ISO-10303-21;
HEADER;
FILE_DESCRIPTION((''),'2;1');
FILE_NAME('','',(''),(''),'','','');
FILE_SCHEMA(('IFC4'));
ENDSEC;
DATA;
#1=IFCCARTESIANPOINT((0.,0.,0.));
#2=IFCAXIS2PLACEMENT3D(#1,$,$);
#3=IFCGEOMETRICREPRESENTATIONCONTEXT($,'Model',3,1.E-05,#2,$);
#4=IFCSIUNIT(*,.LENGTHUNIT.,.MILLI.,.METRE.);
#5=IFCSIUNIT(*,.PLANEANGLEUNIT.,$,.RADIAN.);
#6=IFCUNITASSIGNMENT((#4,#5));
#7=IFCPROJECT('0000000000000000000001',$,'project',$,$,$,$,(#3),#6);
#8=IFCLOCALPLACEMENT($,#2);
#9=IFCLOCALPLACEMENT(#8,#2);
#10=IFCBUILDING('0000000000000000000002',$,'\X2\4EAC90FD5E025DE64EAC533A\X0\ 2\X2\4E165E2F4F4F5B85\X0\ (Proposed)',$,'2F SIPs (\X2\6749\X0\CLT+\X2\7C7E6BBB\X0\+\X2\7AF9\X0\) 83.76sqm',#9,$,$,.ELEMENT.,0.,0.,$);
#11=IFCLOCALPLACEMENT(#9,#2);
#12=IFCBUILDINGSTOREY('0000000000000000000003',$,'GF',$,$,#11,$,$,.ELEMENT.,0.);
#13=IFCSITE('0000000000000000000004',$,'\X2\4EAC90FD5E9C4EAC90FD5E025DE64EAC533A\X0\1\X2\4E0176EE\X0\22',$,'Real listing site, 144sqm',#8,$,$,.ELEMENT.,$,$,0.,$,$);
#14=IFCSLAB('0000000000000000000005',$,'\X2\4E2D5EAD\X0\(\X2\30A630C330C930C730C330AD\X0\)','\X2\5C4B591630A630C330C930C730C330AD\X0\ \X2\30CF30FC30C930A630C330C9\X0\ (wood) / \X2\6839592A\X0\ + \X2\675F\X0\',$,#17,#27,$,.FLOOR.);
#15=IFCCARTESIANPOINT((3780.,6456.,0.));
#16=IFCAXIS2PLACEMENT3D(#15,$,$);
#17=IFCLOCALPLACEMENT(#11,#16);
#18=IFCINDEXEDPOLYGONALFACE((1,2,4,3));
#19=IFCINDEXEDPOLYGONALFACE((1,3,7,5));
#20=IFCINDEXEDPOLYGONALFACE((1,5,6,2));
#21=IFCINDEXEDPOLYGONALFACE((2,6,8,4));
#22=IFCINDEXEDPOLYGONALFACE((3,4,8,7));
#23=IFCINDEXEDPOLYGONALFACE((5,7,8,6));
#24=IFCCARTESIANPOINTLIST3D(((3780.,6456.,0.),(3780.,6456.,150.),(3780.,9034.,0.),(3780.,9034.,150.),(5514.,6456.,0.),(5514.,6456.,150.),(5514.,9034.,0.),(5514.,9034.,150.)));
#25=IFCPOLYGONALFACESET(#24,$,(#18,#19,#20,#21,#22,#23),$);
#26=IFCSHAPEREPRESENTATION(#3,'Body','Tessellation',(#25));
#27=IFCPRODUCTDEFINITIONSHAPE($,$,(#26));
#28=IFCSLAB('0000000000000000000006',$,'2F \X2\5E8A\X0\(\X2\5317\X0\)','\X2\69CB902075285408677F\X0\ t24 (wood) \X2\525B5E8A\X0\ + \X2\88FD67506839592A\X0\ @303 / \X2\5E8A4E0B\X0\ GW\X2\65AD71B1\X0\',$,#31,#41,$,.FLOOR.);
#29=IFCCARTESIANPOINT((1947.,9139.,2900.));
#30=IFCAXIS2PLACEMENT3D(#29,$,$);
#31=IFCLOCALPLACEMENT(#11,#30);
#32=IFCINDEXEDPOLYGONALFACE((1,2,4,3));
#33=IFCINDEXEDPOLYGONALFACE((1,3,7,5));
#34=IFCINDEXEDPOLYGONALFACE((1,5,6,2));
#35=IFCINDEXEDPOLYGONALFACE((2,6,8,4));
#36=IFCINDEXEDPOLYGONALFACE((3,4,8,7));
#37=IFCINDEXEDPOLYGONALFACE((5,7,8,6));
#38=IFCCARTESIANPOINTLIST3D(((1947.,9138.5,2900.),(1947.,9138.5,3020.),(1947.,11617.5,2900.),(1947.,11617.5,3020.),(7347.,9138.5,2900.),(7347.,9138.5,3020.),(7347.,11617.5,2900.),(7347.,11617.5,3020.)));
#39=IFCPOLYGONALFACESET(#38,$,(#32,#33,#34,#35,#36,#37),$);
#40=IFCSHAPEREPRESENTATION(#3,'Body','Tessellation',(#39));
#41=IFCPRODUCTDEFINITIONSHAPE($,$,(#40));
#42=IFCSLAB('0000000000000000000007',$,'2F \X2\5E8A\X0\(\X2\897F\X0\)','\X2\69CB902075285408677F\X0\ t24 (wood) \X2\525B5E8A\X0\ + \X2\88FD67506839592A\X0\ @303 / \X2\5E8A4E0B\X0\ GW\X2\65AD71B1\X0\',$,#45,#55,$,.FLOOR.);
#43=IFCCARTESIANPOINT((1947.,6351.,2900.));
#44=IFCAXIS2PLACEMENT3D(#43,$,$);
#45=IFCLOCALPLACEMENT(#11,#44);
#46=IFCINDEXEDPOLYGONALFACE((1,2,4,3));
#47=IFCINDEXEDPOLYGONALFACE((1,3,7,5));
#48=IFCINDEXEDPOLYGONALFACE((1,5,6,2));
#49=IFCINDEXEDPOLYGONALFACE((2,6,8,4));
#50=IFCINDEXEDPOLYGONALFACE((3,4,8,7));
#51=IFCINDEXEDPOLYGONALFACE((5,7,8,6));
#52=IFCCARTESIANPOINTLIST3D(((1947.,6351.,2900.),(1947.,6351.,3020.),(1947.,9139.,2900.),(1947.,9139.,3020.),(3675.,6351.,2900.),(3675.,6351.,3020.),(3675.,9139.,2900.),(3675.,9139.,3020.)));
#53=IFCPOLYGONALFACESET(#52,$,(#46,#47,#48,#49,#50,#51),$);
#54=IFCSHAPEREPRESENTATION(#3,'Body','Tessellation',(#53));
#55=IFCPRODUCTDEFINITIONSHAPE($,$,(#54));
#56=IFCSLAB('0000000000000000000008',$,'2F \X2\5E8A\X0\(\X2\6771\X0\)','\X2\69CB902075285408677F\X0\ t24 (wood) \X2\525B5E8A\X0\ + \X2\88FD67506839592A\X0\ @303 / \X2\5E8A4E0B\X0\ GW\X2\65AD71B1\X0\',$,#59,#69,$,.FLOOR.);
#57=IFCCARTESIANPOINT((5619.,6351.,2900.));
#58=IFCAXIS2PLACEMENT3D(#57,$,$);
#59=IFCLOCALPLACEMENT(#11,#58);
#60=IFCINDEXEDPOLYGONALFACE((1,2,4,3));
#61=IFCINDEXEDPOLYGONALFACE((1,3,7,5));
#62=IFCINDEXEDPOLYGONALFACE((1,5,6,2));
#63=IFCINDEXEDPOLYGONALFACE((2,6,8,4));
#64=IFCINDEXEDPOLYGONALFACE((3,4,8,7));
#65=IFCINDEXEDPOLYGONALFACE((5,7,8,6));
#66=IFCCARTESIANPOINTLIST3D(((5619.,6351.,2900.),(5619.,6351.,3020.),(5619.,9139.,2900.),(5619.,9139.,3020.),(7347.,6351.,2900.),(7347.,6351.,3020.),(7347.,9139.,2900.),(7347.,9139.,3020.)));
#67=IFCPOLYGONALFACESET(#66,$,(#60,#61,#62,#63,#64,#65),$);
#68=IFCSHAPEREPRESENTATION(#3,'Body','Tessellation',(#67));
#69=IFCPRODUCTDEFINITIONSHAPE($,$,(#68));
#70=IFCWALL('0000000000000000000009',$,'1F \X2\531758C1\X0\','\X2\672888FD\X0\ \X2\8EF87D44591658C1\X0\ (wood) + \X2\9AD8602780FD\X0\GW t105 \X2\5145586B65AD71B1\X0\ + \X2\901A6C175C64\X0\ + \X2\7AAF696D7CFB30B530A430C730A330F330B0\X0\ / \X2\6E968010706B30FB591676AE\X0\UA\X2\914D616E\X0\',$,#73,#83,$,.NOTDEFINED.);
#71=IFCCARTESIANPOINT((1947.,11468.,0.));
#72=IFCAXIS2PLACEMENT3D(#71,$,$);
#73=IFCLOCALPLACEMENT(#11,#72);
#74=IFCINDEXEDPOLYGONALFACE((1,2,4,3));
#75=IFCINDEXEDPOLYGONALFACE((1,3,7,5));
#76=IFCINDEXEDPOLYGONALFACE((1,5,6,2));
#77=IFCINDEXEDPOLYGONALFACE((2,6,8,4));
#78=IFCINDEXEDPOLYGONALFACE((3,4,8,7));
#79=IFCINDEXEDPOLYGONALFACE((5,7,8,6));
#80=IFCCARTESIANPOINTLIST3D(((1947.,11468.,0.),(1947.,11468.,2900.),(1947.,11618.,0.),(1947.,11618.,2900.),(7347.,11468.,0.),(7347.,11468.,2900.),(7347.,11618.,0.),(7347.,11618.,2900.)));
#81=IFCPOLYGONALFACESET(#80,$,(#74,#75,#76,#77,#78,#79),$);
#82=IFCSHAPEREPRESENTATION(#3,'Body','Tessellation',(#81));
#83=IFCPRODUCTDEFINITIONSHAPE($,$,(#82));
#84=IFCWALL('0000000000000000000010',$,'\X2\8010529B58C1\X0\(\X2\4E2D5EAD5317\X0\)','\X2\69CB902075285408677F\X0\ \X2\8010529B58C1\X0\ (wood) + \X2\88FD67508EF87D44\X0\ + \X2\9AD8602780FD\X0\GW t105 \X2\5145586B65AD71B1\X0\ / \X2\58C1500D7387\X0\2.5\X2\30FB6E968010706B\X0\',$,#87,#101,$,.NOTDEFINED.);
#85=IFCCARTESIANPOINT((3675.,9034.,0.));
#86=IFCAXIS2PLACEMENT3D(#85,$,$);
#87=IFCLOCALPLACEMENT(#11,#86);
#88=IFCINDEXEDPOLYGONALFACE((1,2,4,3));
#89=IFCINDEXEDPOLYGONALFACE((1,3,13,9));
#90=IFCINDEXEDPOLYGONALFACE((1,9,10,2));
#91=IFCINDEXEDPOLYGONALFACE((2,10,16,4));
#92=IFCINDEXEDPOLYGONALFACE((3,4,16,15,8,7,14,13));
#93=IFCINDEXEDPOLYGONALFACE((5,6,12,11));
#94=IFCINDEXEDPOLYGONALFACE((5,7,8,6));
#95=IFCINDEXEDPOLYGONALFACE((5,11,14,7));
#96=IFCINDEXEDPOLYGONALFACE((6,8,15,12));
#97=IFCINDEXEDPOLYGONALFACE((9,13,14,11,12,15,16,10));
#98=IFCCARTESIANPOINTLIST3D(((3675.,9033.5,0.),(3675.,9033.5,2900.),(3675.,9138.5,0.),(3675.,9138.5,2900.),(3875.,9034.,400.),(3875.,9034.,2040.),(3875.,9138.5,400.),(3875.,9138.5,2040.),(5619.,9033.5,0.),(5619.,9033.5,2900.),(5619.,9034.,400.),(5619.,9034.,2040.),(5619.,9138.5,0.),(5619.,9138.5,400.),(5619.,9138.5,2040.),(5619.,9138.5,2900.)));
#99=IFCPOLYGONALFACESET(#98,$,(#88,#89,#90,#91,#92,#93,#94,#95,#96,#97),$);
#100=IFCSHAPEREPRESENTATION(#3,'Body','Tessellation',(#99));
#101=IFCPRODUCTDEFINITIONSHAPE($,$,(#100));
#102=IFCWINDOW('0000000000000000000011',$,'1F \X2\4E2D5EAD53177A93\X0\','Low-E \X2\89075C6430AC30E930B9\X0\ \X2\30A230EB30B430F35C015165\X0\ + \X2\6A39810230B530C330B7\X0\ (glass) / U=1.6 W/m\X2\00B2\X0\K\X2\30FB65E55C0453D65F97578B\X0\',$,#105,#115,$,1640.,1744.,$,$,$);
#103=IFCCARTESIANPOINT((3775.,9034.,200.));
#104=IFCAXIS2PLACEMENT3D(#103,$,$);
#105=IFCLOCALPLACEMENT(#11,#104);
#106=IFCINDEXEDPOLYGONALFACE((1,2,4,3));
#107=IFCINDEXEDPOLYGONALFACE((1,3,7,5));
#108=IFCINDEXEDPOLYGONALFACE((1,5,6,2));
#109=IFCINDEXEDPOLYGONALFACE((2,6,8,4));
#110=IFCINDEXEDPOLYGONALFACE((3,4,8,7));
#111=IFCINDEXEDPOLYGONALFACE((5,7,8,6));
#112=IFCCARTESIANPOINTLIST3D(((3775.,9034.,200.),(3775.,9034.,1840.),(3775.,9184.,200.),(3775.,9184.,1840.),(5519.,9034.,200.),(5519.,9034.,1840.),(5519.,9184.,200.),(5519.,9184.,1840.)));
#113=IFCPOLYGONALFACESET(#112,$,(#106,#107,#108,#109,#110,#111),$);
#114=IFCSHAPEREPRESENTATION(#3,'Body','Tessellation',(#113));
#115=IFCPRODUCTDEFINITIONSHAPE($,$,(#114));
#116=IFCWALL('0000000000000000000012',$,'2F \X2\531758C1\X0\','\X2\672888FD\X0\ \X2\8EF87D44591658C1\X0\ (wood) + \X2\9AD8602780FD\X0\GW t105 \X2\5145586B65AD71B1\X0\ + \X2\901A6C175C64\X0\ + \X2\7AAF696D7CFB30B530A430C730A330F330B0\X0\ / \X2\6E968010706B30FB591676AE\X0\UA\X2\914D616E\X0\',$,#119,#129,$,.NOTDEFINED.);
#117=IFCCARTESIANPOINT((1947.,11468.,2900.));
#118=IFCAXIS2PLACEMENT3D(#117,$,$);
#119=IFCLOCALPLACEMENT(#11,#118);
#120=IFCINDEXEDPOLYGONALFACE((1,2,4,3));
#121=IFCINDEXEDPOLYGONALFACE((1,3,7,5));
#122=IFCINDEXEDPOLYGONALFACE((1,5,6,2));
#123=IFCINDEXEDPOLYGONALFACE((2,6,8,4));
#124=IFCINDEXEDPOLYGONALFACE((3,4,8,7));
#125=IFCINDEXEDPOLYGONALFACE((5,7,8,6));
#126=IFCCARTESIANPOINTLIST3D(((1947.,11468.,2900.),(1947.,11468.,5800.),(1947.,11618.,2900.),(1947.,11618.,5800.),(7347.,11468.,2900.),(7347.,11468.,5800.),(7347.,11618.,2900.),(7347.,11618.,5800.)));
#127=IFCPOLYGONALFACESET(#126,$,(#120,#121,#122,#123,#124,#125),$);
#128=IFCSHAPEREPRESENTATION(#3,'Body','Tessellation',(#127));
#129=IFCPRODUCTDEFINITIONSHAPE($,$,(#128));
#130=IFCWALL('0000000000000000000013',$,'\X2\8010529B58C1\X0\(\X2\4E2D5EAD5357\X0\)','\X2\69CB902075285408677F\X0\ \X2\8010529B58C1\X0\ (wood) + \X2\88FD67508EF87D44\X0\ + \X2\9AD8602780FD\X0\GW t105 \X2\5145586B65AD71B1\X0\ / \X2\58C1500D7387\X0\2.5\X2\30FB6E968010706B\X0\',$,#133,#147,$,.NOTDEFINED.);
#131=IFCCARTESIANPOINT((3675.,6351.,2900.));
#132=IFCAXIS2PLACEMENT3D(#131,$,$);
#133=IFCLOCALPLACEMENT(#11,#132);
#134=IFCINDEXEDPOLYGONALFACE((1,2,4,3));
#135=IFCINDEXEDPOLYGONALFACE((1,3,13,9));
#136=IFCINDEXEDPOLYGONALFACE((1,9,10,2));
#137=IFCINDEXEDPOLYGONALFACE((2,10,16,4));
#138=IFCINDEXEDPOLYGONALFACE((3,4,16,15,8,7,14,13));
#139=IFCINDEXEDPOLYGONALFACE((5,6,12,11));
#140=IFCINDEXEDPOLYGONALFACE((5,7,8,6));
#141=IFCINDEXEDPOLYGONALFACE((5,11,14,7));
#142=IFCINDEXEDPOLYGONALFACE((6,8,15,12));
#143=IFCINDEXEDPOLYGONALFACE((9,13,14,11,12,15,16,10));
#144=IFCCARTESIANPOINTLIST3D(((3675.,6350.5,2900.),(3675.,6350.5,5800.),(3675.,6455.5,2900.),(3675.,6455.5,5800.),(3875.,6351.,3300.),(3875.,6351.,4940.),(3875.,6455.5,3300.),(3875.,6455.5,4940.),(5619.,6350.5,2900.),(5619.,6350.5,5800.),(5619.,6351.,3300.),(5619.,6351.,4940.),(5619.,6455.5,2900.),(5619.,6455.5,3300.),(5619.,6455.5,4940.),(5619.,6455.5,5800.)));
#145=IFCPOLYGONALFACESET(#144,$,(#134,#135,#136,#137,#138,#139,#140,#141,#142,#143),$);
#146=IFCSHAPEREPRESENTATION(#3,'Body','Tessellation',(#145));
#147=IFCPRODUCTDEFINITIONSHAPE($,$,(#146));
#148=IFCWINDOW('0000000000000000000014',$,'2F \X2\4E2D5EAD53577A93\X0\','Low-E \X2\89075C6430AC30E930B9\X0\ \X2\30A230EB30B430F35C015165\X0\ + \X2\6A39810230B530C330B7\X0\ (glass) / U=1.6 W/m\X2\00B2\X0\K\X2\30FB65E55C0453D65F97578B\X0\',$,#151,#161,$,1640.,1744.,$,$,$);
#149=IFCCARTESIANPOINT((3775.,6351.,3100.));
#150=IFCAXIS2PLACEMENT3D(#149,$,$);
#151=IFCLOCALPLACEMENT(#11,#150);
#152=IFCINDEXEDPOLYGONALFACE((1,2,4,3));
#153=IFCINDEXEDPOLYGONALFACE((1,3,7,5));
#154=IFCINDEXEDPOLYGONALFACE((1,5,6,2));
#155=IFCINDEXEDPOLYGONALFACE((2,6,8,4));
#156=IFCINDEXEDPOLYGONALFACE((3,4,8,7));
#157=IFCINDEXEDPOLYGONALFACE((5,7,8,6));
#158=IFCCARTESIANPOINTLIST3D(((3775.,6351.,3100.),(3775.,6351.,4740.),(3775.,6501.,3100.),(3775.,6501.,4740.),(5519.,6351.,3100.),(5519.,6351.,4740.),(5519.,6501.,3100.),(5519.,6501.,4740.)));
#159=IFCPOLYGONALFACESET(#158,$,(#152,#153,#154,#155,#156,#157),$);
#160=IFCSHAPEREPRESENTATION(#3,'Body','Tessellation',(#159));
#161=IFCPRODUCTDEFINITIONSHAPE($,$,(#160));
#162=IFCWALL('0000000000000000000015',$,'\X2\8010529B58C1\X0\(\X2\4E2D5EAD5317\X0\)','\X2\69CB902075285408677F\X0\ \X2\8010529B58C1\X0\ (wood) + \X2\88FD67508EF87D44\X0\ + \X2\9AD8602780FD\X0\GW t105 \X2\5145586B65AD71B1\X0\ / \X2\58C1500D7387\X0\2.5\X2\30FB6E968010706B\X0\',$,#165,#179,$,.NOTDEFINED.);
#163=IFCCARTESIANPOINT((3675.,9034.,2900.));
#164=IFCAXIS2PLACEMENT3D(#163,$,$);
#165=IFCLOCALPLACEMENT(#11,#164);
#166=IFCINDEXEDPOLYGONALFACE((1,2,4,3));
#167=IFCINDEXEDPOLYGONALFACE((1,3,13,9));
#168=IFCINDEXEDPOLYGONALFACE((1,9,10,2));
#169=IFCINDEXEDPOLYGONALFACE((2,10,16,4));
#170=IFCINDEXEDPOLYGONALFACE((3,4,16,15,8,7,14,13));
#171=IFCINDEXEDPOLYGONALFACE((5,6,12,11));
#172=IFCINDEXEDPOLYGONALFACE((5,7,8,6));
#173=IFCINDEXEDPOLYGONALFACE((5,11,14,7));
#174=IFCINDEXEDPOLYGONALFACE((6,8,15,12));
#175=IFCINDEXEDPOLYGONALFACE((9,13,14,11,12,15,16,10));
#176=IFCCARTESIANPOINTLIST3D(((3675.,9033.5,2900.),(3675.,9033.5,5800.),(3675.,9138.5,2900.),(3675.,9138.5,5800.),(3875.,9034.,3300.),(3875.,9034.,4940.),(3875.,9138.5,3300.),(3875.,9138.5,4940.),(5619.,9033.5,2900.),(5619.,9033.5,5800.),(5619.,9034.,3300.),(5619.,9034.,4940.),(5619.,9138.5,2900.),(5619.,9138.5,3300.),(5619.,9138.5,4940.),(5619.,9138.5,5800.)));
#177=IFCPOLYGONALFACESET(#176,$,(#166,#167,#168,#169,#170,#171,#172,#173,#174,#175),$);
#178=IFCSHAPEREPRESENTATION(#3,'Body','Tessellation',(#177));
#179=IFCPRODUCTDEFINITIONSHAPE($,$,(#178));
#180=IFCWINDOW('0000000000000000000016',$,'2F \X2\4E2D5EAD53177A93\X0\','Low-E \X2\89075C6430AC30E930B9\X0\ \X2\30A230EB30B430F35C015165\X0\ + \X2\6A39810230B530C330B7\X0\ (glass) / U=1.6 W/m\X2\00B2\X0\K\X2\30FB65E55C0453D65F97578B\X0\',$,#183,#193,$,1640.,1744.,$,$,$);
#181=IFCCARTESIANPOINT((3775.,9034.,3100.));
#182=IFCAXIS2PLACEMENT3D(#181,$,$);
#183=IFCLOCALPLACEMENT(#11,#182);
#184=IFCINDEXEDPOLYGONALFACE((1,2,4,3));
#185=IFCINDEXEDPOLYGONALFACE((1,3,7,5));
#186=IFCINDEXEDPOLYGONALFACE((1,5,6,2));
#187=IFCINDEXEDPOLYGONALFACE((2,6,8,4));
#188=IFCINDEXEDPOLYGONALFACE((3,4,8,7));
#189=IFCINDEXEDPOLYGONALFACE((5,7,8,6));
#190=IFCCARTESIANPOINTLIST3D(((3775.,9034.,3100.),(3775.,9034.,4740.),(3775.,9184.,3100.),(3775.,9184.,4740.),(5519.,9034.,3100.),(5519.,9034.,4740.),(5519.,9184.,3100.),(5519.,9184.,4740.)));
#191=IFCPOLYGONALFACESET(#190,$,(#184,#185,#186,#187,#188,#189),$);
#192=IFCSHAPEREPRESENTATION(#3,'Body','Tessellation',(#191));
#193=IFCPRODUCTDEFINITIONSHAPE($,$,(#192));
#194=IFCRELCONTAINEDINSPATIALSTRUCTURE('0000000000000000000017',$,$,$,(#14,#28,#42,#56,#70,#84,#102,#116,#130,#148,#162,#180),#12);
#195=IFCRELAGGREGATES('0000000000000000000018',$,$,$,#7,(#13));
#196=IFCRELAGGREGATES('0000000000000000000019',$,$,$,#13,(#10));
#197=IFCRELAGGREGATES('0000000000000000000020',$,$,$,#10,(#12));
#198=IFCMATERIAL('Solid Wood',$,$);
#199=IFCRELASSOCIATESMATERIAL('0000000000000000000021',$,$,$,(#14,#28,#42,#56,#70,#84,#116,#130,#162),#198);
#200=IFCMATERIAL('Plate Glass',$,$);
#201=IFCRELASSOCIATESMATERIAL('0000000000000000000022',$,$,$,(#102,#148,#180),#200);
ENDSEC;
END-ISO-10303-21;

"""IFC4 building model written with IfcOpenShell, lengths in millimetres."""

from ifc_helpers import new_model, si_unit, frame, frame_2d, origin, place, context, project, spatial, rectangle, extrude, material, element, fill, save


model = new_model("IFC4")

# Units and contexts
model_context = context("Model", 3, precision=1e-05, world=origin())
ifc_project = project(units=[si_unit("LENGTHUNIT", "METRE", prefix="MILLI"), si_unit("PLANEANGLEUNIT", "RADIAN")], contexts=[model_context])

# Site, building, storey
site_placement = place(None, origin())
site = spatial("IfcSite", under=ifc_project, at=site_placement, Name="京都府京都市左京区1丁目22", ObjectType="Real listing site, 144sqm", CompositionType="ELEMENT", RefElevation=0.0)
building_placement = place(site_placement, origin())
building = spatial("IfcBuilding", under=site, at=building_placement, Name="京都市左京区 2世帯住宅 (Proposed)", ObjectType="2F SIPs (杉CLT+籾殻+竹) 83.76sqm", CompositionType="ELEMENT", ElevationOfRefHeight=0.0, ElevationOfTerrain=0.0)
storey_placement = place(building_placement, origin())
storey = spatial("IfcBuildingStorey", under=building, at=storey_placement, Name="GF", CompositionType="ELEMENT", Elevation=0.0)

# Slabs
ifc_material_1 = material(Name="Solid Wood")
slab_1_placement = place(storey_placement, frame((3780.0, 6456.0, 0.0)))
element("IfcSlab", 1, at=slab_1_placement, inside=storey, material=ifc_material_1, Name="中庭(ウッドデッキ)", Description="屋外ウッドデッキ ハードウッド (wood) / 根太 + 束", PredefinedType="FLOOR", context=model_context, shape_type="SweptSolid", body=[
    extrude(rectangle(XDim=1734.0, YDim=2578.0, at=frame_2d((867.0, 1289.0))), frame((3780.0, 6456.0, 0.0)), (0.0, 0.0, 1.0), 150.0),
])
slab_2_placement = place(storey_placement, frame((1947.0, 9139.0, 2900.0)))
element("IfcSlab", 2, at=slab_2_placement, inside=storey, material=ifc_material_1, Name="2F 床(北)", Description="構造用合板 t24 (wood) 剛床 + 製材根太 @303 / 床下 GW断熱", PredefinedType="FLOOR", context=model_context, shape_type="SweptSolid", body=[
    extrude(rectangle(XDim=5400.0, YDim=2479.0, at=frame_2d((2700.0, 1239.0))), frame((1947.0, 9139.0, 2900.0)), (0.0, 0.0, 1.0), 120.0),
])
slab_3_placement = place(storey_placement, frame((1947.0, 6351.0, 2900.0)))
element("IfcSlab", 3, at=slab_3_placement, inside=storey, material=ifc_material_1, Name="2F 床(西)", Description="構造用合板 t24 (wood) 剛床 + 製材根太 @303 / 床下 GW断熱", PredefinedType="FLOOR", context=model_context, shape_type="SweptSolid", body=[
    extrude(rectangle(XDim=1728.0, YDim=2788.0, at=frame_2d((864.0, 1394.0))), frame((1947.0, 6351.0, 2900.0)), (0.0, 0.0, 1.0), 120.0),
])
slab_4_placement = place(storey_placement, frame((5619.0, 6351.0, 2900.0)))
element("IfcSlab", 4, at=slab_4_placement, inside=storey, material=ifc_material_1, Name="2F 床(東)", Description="構造用合板 t24 (wood) 剛床 + 製材根太 @303 / 床下 GW断熱", PredefinedType="FLOOR", context=model_context, shape_type="SweptSolid", body=[
    extrude(rectangle(XDim=1728.0, YDim=2788.0, at=frame_2d((864.0, 1394.0))), frame((5619.0, 6351.0, 2900.0)), (0.0, 0.0, 1.0), 120.0),
])

# Wall
wall_1_placement = place(storey_placement, frame((1947.0, 11468.0, 0.0)))
element("IfcWall", 5, at=wall_1_placement, inside=storey, material=ifc_material_1, Name="1F 北壁", Description="木製 軸組外壁 (wood) + 高性能GW t105 充填断熱 + 通気層 + 窯業系サイディング / 準耐火・外皮UA配慮", PredefinedType="NOTDEFINED", context=model_context, shape_type="SweptSolid", body=[
    extrude(rectangle(XDim=5400.0, YDim=150.0, at=frame_2d((2700.0, 75.0))), frame((1947.0, 11468.0, 0.0)), (0.0, 0.0, 1.0), 2900.0),
])

# Wall, opening, window
wall_2_placement = place(storey_placement, frame((3675.0, 9034.0, 0.0)))
wall_2 = element("IfcWall", 6, at=wall_2_placement, inside=storey, material=ifc_material_1, Name="耐力壁(中庭北)", Description="構造用合板 耐力壁 (wood) + 製材軸組 + 高性能GW t105 充填断熱 / 壁倍率2.5・準耐火", PredefinedType="NOTDEFINED", context=model_context, shape_type="SweptSolid", body=[
    extrude(rectangle(XDim=1944.0, YDim=105.0, at=frame_2d((972.0, 52.0))), frame((3675.0, 9034.0, 0.0)), (0.0, 0.0, 1.0), 2900.0),
])
opening_1_placement = place(storey_placement, frame((3775.0, 9034.0, 200.0)))
opening_1 = element("IfcOpeningElement", 7, at=opening_1_placement, cuts=wall_2, PredefinedType="NOTDEFINED", context=model_context, shape_type="SweptSolid", body=[
    extrude(rectangle(XDim=1744.0, YDim=150.0, at=frame_2d((872.0, 75.0))), frame((3775.0, 9034.0, 200.0)), (0.0, 0.0, 1.0), 1640.0),
])
ifc_material_2 = material(Name="Plate Glass")
window_1_placement = place(storey_placement, frame((3775.0, 9034.0, 200.0)))
window_1 = element("IfcWindow", 8, at=window_1_placement, inside=storey, material=ifc_material_2, Name="1F 中庭北窓", Description="Low-E 複層ガラス アルゴン封入 + 樹脂サッシ (glass) / U=1.6 W/m²K・日射取得型", OverallHeight=1640.0, OverallWidth=1744.0, context=model_context, shape_type="SweptSolid", body=[
    extrude(rectangle(XDim=1744.0, YDim=150.0, at=frame_2d((872.0, 75.0))), frame((3775.0, 9034.0, 200.0)), (0.0, 0.0, 1.0), 1640.0),
])
fill(opening_1, window_1)

# Wall
wall_3_placement = place(storey_placement, frame((1947.0, 11468.0, 2900.0)))
element("IfcWall", 9, at=wall_3_placement, inside=storey, material=ifc_material_1, Name="2F 北壁", Description="木製 軸組外壁 (wood) + 高性能GW t105 充填断熱 + 通気層 + 窯業系サイディング / 準耐火・外皮UA配慮", PredefinedType="NOTDEFINED", context=model_context, shape_type="SweptSolid", body=[
    extrude(rectangle(XDim=5400.0, YDim=150.0, at=frame_2d((2700.0, 75.0))), frame((1947.0, 11468.0, 2900.0)), (0.0, 0.0, 1.0), 2900.0),
])

# Walls, openings, windows
wall_4_placement = place(storey_placement, frame((3675.0, 6351.0, 2900.0)))
wall_4 = element("IfcWall", 10, at=wall_4_placement, inside=storey, material=ifc_material_1, Name="耐力壁(中庭南)", Description="構造用合板 耐力壁 (wood) + 製材軸組 + 高性能GW t105 充填断熱 / 壁倍率2.5・準耐火", PredefinedType="NOTDEFINED", context=model_context, shape_type="SweptSolid", body=[
    extrude(rectangle(XDim=1944.0, YDim=105.0, at=frame_2d((972.0, 52.0))), frame((3675.0, 6351.0, 2900.0)), (0.0, 0.0, 1.0), 2900.0),
])
opening_2_placement = place(storey_placement, frame((3775.0, 6351.0, 3100.0)))
opening_2 = element("IfcOpeningElement", 11, at=opening_2_placement, cuts=wall_4, PredefinedType="NOTDEFINED", context=model_context, shape_type="SweptSolid", body=[
    extrude(rectangle(XDim=1744.0, YDim=150.0, at=frame_2d((872.0, 75.0))), frame((3775.0, 6351.0, 3100.0)), (0.0, 0.0, 1.0), 1640.0),
])
window_2_placement = place(storey_placement, frame((3775.0, 6351.0, 3100.0)))
window_2 = element("IfcWindow", 12, at=window_2_placement, inside=storey, material=ifc_material_2, Name="2F 中庭南窓", Description="Low-E 複層ガラス アルゴン封入 + 樹脂サッシ (glass) / U=1.6 W/m²K・日射取得型", OverallHeight=1640.0, OverallWidth=1744.0, context=model_context, shape_type="SweptSolid", body=[
    extrude(rectangle(XDim=1744.0, YDim=150.0, at=frame_2d((872.0, 75.0))), frame((3775.0, 6351.0, 3100.0)), (0.0, 0.0, 1.0), 1640.0),
])
fill(opening_2, window_2)
wall_5_placement = place(storey_placement, frame((3675.0, 9034.0, 2900.0)))
wall_5 = element("IfcWall", 13, at=wall_5_placement, inside=storey, material=ifc_material_1, Name="耐力壁(中庭北)", Description="構造用合板 耐力壁 (wood) + 製材軸組 + 高性能GW t105 充填断熱 / 壁倍率2.5・準耐火", PredefinedType="NOTDEFINED", context=model_context, shape_type="SweptSolid", body=[
    extrude(rectangle(XDim=1944.0, YDim=105.0, at=frame_2d((972.0, 52.0))), frame((3675.0, 9034.0, 2900.0)), (0.0, 0.0, 1.0), 2900.0),
])
opening_3_placement = place(storey_placement, frame((3775.0, 9034.0, 3100.0)))
opening_3 = element("IfcOpeningElement", 14, at=opening_3_placement, cuts=wall_5, PredefinedType="NOTDEFINED", context=model_context, shape_type="SweptSolid", body=[
    extrude(rectangle(XDim=1744.0, YDim=150.0, at=frame_2d((872.0, 75.0))), frame((3775.0, 9034.0, 3100.0)), (0.0, 0.0, 1.0), 1640.0),
])
window_3_placement = place(storey_placement, frame((3775.0, 9034.0, 3100.0)))
window_3 = element("IfcWindow", 15, at=window_3_placement, inside=storey, material=ifc_material_2, Name="2F 中庭北窓", Description="Low-E 複層ガラス アルゴン封入 + 樹脂サッシ (glass) / U=1.6 W/m²K・日射取得型", OverallHeight=1640.0, OverallWidth=1744.0, context=model_context, shape_type="SweptSolid", body=[
    extrude(rectangle(XDim=1744.0, YDim=150.0, at=frame_2d((872.0, 75.0))), frame((3775.0, 9034.0, 3100.0)), (0.0, 0.0, 1.0), 1640.0),
])
fill(opening_3, window_3)

save(model, "model.ifc")
